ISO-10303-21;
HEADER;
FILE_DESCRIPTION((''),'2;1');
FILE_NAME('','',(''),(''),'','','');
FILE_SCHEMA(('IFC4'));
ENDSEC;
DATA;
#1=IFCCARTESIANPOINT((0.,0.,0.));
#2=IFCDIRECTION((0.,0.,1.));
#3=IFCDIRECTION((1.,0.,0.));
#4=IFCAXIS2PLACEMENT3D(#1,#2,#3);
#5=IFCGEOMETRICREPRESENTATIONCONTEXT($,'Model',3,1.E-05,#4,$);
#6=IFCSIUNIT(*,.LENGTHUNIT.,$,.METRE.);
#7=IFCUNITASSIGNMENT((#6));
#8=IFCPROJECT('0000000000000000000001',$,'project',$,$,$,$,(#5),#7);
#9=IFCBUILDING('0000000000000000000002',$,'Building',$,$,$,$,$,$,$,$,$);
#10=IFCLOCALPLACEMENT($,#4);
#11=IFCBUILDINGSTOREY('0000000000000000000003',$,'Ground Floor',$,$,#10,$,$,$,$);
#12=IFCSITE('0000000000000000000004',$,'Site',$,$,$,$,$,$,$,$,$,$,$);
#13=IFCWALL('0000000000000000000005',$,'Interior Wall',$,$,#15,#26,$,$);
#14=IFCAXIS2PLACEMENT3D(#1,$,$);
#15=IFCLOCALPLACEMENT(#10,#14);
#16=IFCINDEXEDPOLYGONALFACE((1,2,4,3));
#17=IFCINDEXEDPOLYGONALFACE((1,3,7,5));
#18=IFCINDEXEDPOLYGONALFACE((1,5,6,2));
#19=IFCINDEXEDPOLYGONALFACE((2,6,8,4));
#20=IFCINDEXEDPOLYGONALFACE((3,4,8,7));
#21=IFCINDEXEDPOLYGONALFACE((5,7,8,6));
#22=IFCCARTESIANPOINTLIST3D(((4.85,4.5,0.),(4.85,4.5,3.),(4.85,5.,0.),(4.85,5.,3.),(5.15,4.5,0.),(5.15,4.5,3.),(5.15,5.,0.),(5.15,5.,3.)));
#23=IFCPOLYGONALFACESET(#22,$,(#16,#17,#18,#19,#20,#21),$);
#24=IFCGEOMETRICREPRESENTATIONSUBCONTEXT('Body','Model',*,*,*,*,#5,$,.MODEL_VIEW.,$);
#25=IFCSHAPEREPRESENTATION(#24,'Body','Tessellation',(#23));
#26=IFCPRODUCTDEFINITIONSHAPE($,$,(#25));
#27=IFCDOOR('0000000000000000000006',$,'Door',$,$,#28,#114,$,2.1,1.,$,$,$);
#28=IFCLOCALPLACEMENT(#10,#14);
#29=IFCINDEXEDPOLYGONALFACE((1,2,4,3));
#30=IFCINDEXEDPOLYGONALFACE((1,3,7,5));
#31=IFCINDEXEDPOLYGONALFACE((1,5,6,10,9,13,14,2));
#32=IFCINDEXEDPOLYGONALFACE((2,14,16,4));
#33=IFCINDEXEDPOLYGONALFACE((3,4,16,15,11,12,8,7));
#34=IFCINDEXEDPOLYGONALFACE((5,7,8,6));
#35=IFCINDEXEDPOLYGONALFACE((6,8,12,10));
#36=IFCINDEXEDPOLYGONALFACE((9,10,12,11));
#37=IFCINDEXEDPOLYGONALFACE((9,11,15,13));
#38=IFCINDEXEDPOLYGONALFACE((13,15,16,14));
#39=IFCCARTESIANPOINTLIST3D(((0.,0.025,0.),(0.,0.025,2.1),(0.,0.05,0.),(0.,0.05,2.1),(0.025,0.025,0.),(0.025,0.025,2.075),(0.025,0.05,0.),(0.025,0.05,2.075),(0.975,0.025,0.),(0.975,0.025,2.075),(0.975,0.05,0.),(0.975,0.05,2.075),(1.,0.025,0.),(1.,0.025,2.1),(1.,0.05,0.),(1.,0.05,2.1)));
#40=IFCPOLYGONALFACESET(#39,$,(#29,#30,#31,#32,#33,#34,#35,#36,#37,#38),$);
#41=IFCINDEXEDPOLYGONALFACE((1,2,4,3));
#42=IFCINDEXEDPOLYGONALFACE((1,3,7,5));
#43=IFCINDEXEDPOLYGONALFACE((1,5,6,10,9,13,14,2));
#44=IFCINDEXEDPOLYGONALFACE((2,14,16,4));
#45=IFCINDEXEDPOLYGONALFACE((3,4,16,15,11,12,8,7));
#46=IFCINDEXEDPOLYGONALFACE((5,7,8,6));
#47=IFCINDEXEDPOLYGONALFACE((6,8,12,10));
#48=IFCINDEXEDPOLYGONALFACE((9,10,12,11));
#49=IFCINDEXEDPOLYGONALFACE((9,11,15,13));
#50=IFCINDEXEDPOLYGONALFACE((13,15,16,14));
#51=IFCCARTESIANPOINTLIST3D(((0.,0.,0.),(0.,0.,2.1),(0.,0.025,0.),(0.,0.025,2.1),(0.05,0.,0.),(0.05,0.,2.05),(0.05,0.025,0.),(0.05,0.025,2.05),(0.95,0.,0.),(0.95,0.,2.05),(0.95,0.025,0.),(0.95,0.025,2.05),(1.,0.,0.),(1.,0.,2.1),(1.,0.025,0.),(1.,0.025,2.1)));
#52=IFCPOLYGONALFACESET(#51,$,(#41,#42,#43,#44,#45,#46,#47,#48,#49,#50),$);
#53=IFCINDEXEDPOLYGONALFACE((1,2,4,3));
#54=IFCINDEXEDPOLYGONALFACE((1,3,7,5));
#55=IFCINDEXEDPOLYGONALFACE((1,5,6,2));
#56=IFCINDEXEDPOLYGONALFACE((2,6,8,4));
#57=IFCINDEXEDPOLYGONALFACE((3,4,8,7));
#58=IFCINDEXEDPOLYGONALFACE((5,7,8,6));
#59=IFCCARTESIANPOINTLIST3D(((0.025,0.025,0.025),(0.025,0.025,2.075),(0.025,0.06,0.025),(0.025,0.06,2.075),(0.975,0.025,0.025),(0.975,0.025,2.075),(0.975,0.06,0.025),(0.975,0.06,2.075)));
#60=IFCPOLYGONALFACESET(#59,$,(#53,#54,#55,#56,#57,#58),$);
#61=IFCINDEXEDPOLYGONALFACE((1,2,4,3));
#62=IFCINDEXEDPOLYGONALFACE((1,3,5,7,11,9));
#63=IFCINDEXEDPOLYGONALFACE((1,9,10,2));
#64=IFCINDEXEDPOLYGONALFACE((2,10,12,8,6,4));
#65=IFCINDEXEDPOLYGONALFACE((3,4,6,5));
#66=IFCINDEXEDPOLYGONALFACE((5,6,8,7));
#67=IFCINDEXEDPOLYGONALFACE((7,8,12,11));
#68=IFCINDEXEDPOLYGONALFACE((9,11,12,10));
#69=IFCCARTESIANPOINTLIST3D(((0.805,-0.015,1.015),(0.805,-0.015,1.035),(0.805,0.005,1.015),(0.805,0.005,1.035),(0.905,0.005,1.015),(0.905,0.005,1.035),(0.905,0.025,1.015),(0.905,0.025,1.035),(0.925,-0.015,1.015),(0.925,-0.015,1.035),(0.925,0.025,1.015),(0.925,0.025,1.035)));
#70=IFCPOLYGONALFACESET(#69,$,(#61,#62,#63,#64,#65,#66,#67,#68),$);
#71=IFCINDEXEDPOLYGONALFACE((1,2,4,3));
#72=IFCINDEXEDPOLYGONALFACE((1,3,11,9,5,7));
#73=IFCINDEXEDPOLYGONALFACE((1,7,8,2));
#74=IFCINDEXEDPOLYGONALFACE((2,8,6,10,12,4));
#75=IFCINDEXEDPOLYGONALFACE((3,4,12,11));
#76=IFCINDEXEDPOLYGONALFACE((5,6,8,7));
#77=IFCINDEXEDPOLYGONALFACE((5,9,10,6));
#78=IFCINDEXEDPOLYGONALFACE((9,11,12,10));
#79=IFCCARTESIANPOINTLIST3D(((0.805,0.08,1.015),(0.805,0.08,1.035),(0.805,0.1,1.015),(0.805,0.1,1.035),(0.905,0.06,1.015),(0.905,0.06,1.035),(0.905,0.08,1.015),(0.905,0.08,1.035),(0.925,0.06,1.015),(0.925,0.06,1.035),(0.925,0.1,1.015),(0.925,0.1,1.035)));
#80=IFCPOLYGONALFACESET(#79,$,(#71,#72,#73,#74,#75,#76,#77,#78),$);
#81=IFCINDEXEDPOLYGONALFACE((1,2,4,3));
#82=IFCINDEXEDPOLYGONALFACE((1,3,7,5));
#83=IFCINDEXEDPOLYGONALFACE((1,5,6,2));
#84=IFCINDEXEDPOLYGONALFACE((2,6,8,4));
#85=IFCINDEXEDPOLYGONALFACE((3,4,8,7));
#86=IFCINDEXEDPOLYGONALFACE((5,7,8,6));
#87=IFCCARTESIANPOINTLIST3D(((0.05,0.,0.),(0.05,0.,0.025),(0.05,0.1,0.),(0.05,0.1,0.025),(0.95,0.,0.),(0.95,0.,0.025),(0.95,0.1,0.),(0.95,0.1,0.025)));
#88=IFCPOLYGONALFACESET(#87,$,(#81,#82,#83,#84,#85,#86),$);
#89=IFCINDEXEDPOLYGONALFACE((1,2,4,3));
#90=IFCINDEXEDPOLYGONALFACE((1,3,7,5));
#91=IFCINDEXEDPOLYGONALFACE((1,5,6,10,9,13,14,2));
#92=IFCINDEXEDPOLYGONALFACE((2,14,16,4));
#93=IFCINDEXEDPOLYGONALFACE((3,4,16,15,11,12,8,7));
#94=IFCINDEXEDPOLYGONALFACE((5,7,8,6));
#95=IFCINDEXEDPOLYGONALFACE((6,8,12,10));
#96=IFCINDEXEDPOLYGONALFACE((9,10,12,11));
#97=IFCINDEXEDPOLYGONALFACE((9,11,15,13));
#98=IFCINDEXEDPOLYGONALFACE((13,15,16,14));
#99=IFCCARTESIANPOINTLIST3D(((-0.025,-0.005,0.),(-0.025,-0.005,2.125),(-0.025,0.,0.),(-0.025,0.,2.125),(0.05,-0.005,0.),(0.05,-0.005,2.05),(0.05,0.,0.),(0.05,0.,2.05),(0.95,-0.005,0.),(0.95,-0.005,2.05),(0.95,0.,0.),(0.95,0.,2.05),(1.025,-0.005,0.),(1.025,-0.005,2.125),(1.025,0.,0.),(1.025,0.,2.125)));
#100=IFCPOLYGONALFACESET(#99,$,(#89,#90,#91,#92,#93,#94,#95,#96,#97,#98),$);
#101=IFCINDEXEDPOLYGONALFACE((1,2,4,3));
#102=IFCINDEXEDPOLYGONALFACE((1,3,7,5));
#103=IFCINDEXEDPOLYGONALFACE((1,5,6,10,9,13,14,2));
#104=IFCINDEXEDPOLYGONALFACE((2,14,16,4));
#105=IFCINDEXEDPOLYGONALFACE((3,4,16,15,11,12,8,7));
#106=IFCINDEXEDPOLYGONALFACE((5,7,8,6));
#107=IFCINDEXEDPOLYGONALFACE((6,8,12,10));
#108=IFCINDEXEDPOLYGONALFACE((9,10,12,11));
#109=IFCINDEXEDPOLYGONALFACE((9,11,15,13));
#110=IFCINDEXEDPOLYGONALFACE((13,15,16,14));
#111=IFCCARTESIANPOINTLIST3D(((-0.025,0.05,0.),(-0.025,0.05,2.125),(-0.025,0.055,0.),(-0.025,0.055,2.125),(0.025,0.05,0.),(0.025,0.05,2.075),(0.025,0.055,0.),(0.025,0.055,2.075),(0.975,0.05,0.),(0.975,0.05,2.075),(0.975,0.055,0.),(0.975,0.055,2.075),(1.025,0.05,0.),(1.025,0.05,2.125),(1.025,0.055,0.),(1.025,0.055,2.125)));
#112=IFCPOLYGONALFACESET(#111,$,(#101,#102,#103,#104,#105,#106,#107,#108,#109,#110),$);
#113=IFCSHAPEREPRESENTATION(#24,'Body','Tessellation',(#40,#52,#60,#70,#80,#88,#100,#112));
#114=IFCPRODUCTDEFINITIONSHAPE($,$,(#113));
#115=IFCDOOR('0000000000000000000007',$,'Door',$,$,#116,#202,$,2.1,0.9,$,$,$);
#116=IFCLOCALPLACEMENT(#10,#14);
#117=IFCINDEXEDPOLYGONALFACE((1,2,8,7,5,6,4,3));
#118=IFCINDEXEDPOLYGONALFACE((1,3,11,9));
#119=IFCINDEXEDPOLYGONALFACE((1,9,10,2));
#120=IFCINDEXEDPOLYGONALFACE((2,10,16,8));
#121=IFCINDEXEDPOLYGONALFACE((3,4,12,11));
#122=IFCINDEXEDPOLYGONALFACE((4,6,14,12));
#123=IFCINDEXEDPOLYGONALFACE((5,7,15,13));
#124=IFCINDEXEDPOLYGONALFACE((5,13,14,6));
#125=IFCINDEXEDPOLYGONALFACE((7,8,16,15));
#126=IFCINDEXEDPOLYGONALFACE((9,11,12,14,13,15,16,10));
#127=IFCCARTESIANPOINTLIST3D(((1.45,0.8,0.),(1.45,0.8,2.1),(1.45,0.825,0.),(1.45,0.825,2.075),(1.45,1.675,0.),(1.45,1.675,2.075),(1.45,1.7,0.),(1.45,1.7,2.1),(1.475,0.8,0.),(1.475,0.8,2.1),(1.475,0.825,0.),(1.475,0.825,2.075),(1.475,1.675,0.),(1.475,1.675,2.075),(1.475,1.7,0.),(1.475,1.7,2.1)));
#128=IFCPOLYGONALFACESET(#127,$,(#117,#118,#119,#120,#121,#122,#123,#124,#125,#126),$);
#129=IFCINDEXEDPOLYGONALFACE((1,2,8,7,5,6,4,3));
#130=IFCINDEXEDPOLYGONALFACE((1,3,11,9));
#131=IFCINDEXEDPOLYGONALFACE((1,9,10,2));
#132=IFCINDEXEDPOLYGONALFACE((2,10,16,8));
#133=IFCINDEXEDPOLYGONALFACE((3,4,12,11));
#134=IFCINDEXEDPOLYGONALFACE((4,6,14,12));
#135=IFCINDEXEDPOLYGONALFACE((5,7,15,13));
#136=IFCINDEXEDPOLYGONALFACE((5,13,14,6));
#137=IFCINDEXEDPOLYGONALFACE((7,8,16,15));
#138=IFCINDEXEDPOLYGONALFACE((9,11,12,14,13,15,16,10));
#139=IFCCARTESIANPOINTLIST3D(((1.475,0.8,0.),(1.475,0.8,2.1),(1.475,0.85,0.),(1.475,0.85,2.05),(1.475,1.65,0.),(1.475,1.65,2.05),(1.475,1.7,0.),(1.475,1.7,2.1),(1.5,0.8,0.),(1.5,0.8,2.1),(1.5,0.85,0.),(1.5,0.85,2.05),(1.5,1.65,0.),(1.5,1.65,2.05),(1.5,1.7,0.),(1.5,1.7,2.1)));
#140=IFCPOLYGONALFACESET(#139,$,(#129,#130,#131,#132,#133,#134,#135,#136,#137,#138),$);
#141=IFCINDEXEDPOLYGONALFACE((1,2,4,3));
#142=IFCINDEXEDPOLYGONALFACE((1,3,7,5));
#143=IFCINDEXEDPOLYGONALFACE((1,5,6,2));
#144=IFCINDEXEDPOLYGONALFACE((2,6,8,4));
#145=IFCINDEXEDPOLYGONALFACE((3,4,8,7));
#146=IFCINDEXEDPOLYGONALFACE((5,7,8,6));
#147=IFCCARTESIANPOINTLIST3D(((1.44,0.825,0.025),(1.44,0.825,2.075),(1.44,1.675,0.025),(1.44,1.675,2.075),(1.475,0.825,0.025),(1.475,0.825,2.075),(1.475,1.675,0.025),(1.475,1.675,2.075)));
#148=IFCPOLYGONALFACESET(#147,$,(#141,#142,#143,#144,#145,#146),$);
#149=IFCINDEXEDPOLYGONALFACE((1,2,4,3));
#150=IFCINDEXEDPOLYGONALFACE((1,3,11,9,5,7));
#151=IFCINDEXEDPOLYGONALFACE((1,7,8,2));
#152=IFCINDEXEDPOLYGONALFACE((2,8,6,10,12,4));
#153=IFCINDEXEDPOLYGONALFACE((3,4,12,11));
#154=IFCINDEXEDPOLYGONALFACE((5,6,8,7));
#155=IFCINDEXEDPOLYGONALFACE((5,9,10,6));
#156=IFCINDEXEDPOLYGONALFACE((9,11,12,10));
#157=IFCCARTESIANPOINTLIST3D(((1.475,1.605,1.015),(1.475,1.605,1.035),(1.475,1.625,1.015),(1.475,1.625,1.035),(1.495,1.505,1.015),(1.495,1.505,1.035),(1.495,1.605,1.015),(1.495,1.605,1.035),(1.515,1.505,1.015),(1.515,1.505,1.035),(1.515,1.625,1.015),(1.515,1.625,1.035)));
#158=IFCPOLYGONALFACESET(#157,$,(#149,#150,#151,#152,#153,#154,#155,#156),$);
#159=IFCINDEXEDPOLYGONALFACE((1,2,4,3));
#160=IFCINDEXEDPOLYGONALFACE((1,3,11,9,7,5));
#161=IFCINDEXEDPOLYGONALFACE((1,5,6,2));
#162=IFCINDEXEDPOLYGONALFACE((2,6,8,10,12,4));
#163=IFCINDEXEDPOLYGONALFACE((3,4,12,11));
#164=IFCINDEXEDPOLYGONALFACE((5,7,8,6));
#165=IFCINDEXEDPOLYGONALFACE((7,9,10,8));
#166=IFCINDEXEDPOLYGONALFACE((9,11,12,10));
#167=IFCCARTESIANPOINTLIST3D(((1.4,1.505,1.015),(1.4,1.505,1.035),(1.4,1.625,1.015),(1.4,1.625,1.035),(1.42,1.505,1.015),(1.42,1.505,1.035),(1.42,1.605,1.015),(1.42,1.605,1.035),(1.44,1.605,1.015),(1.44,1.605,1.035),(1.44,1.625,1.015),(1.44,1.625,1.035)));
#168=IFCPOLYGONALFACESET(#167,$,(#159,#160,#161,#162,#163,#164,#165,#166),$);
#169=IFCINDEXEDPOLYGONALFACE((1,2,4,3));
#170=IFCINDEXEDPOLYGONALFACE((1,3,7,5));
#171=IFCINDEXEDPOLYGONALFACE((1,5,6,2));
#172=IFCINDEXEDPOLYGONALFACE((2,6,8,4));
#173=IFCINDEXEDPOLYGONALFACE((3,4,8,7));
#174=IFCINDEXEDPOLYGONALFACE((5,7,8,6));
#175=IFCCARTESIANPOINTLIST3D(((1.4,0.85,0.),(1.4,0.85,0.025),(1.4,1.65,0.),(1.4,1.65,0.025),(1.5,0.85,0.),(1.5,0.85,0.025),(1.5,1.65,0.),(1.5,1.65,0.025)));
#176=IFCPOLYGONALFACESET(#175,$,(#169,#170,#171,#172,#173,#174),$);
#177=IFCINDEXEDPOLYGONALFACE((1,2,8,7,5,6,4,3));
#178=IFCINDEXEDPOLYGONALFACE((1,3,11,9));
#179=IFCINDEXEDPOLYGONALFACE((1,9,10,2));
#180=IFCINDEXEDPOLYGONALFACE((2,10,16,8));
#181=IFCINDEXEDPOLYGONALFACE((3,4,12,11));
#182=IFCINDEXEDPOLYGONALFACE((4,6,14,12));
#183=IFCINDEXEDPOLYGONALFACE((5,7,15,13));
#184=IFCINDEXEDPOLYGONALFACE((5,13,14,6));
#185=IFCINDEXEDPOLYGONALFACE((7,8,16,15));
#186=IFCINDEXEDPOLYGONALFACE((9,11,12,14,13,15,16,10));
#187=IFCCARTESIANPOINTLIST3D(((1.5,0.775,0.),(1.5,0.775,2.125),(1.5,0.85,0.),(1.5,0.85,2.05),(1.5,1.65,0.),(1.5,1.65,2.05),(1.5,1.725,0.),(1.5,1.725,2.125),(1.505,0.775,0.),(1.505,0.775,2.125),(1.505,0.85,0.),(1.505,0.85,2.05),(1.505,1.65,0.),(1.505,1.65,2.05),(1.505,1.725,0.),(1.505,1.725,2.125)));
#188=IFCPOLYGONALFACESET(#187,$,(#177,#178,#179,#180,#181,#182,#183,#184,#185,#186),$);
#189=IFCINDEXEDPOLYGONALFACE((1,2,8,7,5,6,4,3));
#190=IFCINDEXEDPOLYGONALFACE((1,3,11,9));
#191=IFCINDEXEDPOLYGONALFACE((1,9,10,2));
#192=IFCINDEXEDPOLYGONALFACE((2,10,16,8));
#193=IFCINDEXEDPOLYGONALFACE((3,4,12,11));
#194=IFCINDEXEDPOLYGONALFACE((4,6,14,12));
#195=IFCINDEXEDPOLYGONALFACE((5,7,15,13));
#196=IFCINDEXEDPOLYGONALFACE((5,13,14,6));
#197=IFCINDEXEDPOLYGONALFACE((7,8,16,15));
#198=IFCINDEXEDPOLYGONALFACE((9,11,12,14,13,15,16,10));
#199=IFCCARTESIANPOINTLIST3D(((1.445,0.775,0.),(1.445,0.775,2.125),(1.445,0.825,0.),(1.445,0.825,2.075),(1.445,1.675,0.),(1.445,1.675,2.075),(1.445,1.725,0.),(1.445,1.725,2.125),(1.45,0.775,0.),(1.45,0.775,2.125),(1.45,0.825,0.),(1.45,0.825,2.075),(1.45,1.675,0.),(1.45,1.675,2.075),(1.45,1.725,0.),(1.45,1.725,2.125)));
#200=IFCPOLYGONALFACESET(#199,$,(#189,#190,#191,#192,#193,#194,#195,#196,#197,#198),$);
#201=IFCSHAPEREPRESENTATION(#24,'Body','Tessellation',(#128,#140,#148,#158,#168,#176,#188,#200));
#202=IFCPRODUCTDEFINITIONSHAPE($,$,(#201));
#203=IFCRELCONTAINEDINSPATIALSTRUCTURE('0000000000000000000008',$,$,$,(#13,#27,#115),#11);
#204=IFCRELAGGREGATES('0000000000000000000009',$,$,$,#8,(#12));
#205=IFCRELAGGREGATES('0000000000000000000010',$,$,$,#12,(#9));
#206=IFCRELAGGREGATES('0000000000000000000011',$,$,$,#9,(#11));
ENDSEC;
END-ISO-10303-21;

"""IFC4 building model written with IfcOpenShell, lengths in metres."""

from ifc_helpers import new_model, si_unit, frame, origin_with_axes, place, context, subcontext, project, spatial, line, indexed_curve, outline, extrude, element, save


model = new_model("IFC4")

# Units and contexts
model_context = context("Model", 3, precision=1e-05, world=origin_with_axes())
body_context = subcontext(model_context, "Body", "Model", "MODEL_VIEW")
ifc_project = project(units=[si_unit("LENGTHUNIT", "METRE")], contexts=[model_context])

# Site, building, storey
site = spatial("IfcSite", under=ifc_project, Name="Site")
building = spatial("IfcBuilding", under=site, Name="Building")
storey_placement = place(None, origin_with_axes())
storey = spatial("IfcBuildingStorey", under=building, at=storey_placement, Name="Ground Floor")

# Wall
for number, where, z_axis, x_axis, name in (
    (1, (5.0, 4.5, 0.0), (0.0, 0.0, 1.0), (0.0, 1.0, 0.0), "Interior Wall"),
):
    element("IfcWall", number, at=place(storey_placement, frame(where, z_axis=z_axis, x_axis=x_axis)), inside=storey, Name=name, context=body_context, shape_type="SweptSolid", body=[
        extrude(outline(indexed_curve([(0.0, 0.0), (0.0, 0.3), (0.5, 0.3), (0.5, 0.0), (0.0, 0.0)], self_intersect=False)), frame((0.0, -0.15, 0.0), z_axis=(0.0, 0.0, 1.0), x_axis=(1.0, 0.0, 0.0)), (0.0, 0.0, 1.0), 3.0),
    ])

# Doors
door_1_placement = place(storey_placement, origin_with_axes())
element("IfcDoor", 2, at=door_1_placement, inside=storey, Name="Door", OverallHeight=2.1, OverallWidth=1.0, context=body_context, shape_type="SweptSolid", body=[
    extrude(outline(indexed_curve([(0.0, 0.0), (0.0, 2.1), (1.0, 2.1), (1.0, 0.0), (0.975, 0.0), (0.975, 2.075), (0.025, 2.075), (0.025, 0.0)], segments=[line(1, 2, 3, 4, 5, 6, 7, 8, 1)])), frame((0.0, 0.025, 0.0), z_axis=(0.0, -1.0, 0.0), x_axis=(1.0, 0.0, 0.0)), (0.0, 0.0, -1.0), 0.025),
    extrude(outline(indexed_curve([(0.0, 0.0), (0.0, 2.1), (1.0, 2.1), (1.0, 0.0), (0.95, 0.0), (0.95, 2.05), (0.05, 2.05), (0.05, 0.0)], segments=[line(1, 2, 3, 4, 5, 6, 7, 8, 1)])), frame((0.0, 0.0, 0.0), z_axis=(0.0, -1.0, 0.0), x_axis=(1.0, 0.0, 0.0)), (0.0, 0.0, -1.0), 0.025),
    extrude(outline(indexed_curve([(0.0, 0.0), (0.95, 0.0), (0.95, 0.035), (0.0, 0.035)], segments=[line(1, 2, 3, 4, 1)])), frame((0.025, 0.025, 0.025), z_axis=(0.0, 0.0, 1.0), x_axis=(1.0, 0.0, 0.0)), (0.0, 0.0, 1.0), 2.05),
    extrude(outline(indexed_curve([(0.0, 0.0), (0.0, -0.04), (-0.12, -0.04), (-0.12, -0.02), (-0.02, -0.02), (-0.02, 0.0)], segments=[line(1, 2, 3, 4, 5, 6, 1)])), frame((0.925, 0.025, 1.015), z_axis=(0.0, 0.0, 1.0), x_axis=(1.0, 0.0, 0.0)), (0.0, 0.0, 1.0), 0.02),
    extrude(outline(indexed_curve([(0.0, 0.0), (0.0, 0.04), (-0.12, 0.04), (-0.12, 0.02), (-0.02, 0.02), (-0.02, 0.0)], segments=[line(1, 2, 3, 4, 5, 6, 1)])), frame((0.925, 0.06, 1.015), z_axis=(0.0, 0.0, 1.0), x_axis=(1.0, 0.0, 0.0)), (0.0, 0.0, 1.0), 0.02),
    extrude(outline(indexed_curve([(0.0, 0.0), (0.9, 0.0), (0.9, 0.1), (0.0, 0.1)], segments=[line(1, 2, 3, 4, 1)])), frame((0.05, 0.0, 0.0), z_axis=(0.0, 0.0, 1.0), x_axis=(1.0, 0.0, 0.0)), (0.0, 0.0, 1.0), 0.025),
    extrude(outline(indexed_curve([(0.0, 0.0), (0.0, 2.125), (1.05, 2.125), (1.05, 0.0), (0.975, 0.0), (0.975, 2.05), (0.075, 2.05), (0.075, 0.0)], segments=[line(1, 2, 3, 4, 5, 6, 7, 8, 1)])), frame((-0.025, -0.005, 0.0), z_axis=(0.0, -1.0, 0.0), x_axis=(1.0, 0.0, 0.0)), (0.0, 0.0, -1.0), 0.005),
    extrude(outline(indexed_curve([(0.0, 0.0), (0.0, 2.125), (1.05, 2.125), (1.05, 0.0), (1.0, 0.0), (1.0, 2.075), (0.05, 2.075), (0.05, 0.0)], segments=[line(1, 2, 3, 4, 5, 6, 7, 8, 1)])), frame((-0.025, 0.05, 0.0), z_axis=(0.0, -1.0, 0.0), x_axis=(1.0, 0.0, 0.0)), (0.0, 0.0, -1.0), 0.005),
])
door_2_placement = place(storey_placement, frame((1.5, 0.8, 0.0), z_axis=(0.0, 0.0, 1.0), x_axis=(0.0, 1.0, 0.0)))
element("IfcDoor", 3, at=door_2_placement, inside=storey, Name="Door", OverallHeight=2.1, OverallWidth=0.9, context=body_context, shape_type="SweptSolid", body=[
    extrude(outline(indexed_curve([(0.0, 0.0), (0.0, 2.1), (0.9, 2.1), (0.9, 0.0), (0.875, 0.0), (0.875, 2.075), (0.025, 2.075), (0.025, 0.0)], segments=[line(1, 2, 3, 4, 5, 6, 7, 8, 1)])), frame((0.0, 0.025, 0.0), z_axis=(0.0, -1.0, 0.0), x_axis=(1.0, 0.0, 0.0)), (0.0, 0.0, -1.0), 0.025),
    extrude(outline(indexed_curve([(0.0, 0.0), (0.0, 2.1), (0.9, 2.1), (0.9, 0.0), (0.85, 0.0), (0.85, 2.05), (0.05, 2.05), (0.05, 0.0)], segments=[line(1, 2, 3, 4, 5, 6, 7, 8, 1)])), frame((0.0, 0.0, 0.0), z_axis=(0.0, -1.0, 0.0), x_axis=(1.0, 0.0, 0.0)), (0.0, 0.0, -1.0), 0.025),
    extrude(outline(indexed_curve([(0.0, 0.0), (0.85, 0.0), (0.85, 0.035), (0.0, 0.035)], segments=[line(1, 2, 3, 4, 1)])), frame((0.025, 0.025, 0.025), z_axis=(0.0, 0.0, 1.0), x_axis=(1.0, 0.0, 0.0)), (0.0, 0.0, 1.0), 2.05),
    extrude(outline(indexed_curve([(0.0, 0.0), (0.0, -0.04), (-0.12, -0.04), (-0.12, -0.02), (-0.02, -0.02), (-0.02, 0.0)], segments=[line(1, 2, 3, 4, 5, 6, 1)])), frame((0.825, 0.025, 1.015), z_axis=(0.0, 0.0, 1.0), x_axis=(1.0, 0.0, 0.0)), (0.0, 0.0, 1.0), 0.02),
    extrude(outline(indexed_curve([(0.0, 0.0), (0.0, 0.04), (-0.12, 0.04), (-0.12, 0.02), (-0.02, 0.02), (-0.02, 0.0)], segments=[line(1, 2, 3, 4, 5, 6, 1)])), frame((0.825, 0.06, 1.015), z_axis=(0.0, 0.0, 1.0), x_axis=(1.0, 0.0, 0.0)), (0.0, 0.0, 1.0), 0.02),
    extrude(outline(indexed_curve([(0.0, 0.0), (0.8, 0.0), (0.8, 0.1), (0.0, 0.1)], segments=[line(1, 2, 3, 4, 1)])), frame((0.05, 0.0, 0.0), z_axis=(0.0, 0.0, 1.0), x_axis=(1.0, 0.0, 0.0)), (0.0, 0.0, 1.0), 0.025),
    extrude(outline(indexed_curve([(0.0, 0.0), (0.0, 2.125), (0.95, 2.125), (0.95, 0.0), (0.875, 0.0), (0.875, 2.05), (0.075, 2.05), (0.075, 0.0)], segments=[line(1, 2, 3, 4, 5, 6, 7, 8, 1)])), frame((-0.025, -0.005, 0.0), z_axis=(0.0, -1.0, 0.0), x_axis=(1.0, 0.0, 0.0)), (0.0, 0.0, -1.0), 0.005),
    extrude(outline(indexed_curve([(0.0, 0.0), (0.0, 2.125), (0.95, 2.125), (0.95, 0.0), (0.9, 0.0), (0.9, 2.075), (0.05, 2.075), (0.05, 0.0)], segments=[line(1, 2, 3, 4, 5, 6, 7, 8, 1)])), frame((-0.025, 0.05, 0.0), z_axis=(0.0, -1.0, 0.0), x_axis=(1.0, 0.0, 0.0)), (0.0, 0.0, -1.0), 0.005),
])

save(model, "model.ifc")
